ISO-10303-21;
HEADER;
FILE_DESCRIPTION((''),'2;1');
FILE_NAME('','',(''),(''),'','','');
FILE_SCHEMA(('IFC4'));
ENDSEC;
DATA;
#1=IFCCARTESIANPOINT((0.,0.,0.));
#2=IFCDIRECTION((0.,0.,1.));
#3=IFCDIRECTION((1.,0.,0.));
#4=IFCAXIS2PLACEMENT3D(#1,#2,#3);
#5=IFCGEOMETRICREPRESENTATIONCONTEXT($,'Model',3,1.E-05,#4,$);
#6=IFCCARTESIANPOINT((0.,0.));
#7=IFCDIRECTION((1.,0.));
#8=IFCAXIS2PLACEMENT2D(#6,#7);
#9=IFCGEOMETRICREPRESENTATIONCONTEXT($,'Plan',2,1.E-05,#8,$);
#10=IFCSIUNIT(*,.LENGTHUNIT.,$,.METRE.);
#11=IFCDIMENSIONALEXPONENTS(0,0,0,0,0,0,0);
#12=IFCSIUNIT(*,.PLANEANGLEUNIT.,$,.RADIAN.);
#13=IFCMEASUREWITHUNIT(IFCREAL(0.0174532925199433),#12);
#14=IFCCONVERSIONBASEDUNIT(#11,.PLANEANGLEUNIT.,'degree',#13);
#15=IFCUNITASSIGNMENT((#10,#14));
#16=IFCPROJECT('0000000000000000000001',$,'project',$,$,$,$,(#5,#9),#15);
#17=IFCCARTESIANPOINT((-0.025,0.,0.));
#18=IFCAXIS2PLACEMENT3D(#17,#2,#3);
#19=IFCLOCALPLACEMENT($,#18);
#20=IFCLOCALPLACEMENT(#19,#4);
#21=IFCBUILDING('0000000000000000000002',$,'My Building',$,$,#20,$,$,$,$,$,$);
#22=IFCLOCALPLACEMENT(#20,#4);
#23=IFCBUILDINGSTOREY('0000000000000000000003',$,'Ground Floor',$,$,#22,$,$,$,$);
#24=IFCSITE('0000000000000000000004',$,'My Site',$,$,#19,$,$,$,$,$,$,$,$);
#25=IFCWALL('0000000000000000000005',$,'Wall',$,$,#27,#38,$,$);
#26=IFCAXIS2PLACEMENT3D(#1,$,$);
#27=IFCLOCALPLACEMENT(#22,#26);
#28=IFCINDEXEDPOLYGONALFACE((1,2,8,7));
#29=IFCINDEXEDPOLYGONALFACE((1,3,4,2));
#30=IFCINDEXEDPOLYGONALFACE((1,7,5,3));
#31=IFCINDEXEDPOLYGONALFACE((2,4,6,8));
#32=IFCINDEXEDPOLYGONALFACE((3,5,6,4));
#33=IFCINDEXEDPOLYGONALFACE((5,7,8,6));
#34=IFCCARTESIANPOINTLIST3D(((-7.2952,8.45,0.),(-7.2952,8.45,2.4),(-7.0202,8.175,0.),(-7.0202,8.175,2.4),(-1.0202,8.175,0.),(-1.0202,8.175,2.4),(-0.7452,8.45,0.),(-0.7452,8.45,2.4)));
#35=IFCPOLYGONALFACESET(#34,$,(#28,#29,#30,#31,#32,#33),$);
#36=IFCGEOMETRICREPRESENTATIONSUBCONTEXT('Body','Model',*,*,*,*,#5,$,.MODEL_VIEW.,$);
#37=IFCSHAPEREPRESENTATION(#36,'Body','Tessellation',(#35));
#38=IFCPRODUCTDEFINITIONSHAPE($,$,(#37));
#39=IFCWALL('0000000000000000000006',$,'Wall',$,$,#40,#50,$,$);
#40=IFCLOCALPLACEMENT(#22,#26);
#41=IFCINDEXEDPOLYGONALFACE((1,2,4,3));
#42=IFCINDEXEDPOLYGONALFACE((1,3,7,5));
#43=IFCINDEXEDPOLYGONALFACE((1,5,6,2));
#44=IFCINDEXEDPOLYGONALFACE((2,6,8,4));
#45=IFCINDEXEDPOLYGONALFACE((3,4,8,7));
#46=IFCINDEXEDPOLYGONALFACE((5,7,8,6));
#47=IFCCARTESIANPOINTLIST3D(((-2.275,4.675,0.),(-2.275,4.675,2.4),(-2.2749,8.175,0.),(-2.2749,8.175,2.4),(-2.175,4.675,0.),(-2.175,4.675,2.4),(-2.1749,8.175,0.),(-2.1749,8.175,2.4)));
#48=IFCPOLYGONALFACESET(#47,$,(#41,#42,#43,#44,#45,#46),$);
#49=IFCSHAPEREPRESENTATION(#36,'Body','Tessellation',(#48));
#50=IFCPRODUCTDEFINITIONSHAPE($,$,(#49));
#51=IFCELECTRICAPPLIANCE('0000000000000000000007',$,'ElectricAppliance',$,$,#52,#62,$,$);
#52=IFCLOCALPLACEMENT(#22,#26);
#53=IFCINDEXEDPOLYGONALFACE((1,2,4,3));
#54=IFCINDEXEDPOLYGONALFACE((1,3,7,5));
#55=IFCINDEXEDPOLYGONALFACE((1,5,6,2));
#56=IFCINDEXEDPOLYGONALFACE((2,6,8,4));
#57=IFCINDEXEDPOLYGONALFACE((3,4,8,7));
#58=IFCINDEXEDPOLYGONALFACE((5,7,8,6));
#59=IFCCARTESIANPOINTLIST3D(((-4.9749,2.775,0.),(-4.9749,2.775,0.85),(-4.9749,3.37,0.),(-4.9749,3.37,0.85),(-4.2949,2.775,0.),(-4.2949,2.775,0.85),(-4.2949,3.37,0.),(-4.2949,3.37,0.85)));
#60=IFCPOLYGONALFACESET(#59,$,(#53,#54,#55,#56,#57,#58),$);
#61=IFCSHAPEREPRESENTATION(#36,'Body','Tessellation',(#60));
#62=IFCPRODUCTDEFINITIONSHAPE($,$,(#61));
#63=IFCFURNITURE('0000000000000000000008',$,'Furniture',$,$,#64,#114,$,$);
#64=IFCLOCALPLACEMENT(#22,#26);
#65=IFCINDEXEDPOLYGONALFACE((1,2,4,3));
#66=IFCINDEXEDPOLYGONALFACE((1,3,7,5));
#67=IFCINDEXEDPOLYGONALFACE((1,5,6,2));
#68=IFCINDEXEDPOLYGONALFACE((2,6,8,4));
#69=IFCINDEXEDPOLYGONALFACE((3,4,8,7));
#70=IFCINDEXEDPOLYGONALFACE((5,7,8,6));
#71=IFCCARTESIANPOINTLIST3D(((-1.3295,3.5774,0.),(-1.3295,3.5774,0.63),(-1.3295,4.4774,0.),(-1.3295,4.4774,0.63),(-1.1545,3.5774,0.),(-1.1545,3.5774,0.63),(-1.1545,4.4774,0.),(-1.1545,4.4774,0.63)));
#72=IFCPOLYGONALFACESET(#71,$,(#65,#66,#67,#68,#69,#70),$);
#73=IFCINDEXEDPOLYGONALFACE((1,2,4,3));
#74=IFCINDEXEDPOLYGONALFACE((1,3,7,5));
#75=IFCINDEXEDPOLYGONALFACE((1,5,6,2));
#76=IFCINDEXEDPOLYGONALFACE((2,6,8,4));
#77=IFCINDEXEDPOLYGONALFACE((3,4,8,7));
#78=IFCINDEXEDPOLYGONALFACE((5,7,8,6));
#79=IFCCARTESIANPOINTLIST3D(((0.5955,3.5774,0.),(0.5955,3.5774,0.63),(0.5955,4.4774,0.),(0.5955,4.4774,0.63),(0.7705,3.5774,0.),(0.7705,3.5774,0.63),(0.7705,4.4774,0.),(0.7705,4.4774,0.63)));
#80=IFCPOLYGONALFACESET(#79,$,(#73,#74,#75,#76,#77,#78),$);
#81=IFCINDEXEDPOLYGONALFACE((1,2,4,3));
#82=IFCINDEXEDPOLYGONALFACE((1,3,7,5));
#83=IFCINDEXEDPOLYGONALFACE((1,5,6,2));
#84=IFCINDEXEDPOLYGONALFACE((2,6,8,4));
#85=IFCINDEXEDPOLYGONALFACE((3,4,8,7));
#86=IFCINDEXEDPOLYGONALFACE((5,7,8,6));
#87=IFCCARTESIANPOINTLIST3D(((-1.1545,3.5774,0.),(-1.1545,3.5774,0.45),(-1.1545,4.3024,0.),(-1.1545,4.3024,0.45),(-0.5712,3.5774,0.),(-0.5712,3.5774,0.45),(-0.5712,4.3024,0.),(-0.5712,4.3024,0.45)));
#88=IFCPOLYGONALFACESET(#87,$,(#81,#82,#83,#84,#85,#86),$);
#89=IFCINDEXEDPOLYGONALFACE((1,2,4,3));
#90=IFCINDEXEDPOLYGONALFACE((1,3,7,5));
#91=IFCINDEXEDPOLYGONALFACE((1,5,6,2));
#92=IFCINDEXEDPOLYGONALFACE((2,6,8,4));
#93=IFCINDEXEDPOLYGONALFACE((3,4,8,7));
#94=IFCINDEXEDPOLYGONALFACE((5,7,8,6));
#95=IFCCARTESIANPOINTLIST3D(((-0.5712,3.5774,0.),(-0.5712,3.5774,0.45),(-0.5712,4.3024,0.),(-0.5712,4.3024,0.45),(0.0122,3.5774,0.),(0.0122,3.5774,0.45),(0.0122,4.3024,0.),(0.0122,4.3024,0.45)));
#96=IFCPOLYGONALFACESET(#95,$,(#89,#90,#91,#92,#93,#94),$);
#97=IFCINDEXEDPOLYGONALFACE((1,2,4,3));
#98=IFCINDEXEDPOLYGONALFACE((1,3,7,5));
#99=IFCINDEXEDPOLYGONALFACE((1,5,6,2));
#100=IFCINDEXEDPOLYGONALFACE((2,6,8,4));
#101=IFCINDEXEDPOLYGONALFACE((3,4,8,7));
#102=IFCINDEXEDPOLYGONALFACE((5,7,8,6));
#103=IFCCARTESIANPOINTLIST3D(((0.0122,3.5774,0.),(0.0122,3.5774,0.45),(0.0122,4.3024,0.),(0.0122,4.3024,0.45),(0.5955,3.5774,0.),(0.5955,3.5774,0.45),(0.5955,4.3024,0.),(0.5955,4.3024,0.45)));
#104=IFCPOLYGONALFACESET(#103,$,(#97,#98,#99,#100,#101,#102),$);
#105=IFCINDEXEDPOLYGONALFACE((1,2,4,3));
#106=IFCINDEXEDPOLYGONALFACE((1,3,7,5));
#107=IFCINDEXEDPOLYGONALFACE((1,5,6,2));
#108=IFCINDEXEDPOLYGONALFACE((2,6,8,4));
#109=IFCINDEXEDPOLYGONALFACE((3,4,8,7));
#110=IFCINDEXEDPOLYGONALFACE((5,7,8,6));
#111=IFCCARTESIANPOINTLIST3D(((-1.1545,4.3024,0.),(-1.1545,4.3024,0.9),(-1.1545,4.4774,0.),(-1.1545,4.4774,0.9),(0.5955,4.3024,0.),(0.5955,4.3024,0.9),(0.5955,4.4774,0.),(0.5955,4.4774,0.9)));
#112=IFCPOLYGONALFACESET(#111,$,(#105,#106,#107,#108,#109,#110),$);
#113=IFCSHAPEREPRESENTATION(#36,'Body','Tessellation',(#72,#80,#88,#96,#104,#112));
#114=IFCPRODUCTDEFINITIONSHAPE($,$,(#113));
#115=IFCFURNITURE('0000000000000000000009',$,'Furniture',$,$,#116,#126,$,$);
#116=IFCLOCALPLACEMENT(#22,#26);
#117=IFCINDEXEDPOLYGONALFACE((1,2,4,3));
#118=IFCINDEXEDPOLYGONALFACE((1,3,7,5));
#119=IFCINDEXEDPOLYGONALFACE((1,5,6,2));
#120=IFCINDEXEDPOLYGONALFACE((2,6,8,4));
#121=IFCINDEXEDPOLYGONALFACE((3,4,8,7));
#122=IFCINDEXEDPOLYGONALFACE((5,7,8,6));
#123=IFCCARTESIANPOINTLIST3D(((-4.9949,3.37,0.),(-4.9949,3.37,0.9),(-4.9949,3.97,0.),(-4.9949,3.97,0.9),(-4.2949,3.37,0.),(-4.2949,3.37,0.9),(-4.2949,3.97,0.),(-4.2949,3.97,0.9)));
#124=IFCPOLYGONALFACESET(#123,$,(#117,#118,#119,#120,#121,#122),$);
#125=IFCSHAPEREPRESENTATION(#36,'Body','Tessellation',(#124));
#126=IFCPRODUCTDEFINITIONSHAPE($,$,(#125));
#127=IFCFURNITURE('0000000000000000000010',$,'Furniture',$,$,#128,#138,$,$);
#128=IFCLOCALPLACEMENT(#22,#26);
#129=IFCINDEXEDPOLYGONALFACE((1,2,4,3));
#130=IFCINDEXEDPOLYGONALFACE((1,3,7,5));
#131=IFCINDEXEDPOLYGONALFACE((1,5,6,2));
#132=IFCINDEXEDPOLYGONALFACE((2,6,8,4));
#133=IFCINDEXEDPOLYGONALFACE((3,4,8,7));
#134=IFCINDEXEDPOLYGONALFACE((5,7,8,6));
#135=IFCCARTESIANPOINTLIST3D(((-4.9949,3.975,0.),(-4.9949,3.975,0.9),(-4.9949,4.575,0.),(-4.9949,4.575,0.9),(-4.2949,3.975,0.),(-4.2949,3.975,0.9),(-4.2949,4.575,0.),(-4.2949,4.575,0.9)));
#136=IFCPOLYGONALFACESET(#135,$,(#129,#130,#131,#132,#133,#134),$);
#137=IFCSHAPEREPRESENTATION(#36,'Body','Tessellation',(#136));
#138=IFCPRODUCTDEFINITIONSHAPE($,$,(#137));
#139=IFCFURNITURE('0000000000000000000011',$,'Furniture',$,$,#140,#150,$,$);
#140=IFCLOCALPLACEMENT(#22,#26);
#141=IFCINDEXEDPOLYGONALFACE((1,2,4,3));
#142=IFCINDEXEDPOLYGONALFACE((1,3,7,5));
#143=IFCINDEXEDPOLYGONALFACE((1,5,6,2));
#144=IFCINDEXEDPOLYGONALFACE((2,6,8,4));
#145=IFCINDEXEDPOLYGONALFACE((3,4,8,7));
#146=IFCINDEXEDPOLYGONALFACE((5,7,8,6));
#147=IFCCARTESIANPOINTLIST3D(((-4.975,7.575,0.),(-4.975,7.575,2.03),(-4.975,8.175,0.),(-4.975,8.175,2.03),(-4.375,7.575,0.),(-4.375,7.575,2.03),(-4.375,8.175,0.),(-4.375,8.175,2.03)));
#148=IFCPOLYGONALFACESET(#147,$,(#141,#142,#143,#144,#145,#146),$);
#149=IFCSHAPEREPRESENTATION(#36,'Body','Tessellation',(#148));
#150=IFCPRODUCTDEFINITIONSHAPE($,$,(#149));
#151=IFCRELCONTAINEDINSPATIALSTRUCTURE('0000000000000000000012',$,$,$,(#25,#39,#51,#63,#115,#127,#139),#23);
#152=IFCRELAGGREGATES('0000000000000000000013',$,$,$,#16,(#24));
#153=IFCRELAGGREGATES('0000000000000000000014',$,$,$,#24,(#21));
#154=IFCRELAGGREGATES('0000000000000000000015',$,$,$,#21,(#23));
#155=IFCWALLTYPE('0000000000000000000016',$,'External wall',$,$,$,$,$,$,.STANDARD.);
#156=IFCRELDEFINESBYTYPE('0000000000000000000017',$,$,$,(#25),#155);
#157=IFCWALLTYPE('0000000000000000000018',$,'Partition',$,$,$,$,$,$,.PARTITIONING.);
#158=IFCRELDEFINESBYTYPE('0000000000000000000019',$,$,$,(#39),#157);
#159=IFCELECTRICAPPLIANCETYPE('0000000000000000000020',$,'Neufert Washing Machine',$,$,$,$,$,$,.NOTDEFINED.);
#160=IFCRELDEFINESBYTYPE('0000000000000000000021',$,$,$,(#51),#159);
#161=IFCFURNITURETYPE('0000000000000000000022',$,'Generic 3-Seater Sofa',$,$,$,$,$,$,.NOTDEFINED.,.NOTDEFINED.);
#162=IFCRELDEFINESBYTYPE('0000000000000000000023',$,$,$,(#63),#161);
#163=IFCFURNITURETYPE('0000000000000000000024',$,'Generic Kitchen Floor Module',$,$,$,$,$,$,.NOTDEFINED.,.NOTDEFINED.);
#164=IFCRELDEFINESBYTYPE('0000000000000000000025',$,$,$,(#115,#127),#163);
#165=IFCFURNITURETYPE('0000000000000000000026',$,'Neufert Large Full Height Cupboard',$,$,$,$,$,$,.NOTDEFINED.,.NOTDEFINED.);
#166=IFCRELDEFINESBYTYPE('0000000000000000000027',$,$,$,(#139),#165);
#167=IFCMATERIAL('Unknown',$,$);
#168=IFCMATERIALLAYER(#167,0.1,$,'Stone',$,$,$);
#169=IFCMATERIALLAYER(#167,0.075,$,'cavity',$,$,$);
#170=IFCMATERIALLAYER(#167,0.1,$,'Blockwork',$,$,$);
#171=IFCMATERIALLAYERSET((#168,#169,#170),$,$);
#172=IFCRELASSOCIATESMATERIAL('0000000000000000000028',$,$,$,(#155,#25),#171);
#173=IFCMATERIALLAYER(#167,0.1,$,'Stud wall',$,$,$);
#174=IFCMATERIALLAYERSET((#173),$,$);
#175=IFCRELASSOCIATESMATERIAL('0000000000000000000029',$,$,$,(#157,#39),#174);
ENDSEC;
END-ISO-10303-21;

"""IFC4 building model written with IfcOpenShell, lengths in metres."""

from ifc_helpers import new_model, entity, si_unit, converted_unit, frame, origin_with_axes, origin_2d_with_axis, place, context, subcontext, project, spatial, line, indexed_curve, outline, extrude, clip, halfspace, shape, source, transform, mapped, material, layer, layer_set, layer_usage, type_object, type_shapes, element, save


model = new_model("IFC4")

# Units and contexts
model_context = context("Model", 3, precision=1e-05, world=origin_with_axes())
plan_context = context("Plan", 2, precision=1e-05, world=origin_2d_with_axis())
body_context_1 = subcontext(model_context, "Body", "Model", "MODEL_VIEW")
body_context_2 = subcontext(plan_context, "Body", "Plan", "PLAN_VIEW")
ifc_project = project(units=[si_unit("LENGTHUNIT", "METRE"), converted_unit("PLANEANGLEUNIT", "degree", entity("IfcReal", 0.0174532925199433), si_unit("PLANEANGLEUNIT", "RADIAN"), dimensions=[0, 0, 0, 0, 0, 0, 0])], contexts=[model_context, plan_context])

# Site, building, storey
site_placement = place(None, frame((-0.025, 0.0, 0.0), z_axis=(0.0, 0.0, 1.0), x_axis=(1.0, 0.0, 0.0)))
site = spatial("IfcSite", under=ifc_project, at=site_placement, Name="My Site")
building_placement = place(site_placement, origin_with_axes())
building = spatial("IfcBuilding", under=site, at=building_placement, Name="My Building")
storey_placement = place(building_placement, frame((0.0, 0.0, 0.0), z_axis=(0.0, 0.0, 1.0), x_axis=(1.0, 0.0, 0.0)))
storey = spatial("IfcBuildingStorey", under=building, at=storey_placement, Name="Ground Floor")

# Wall
ifc_material = material(Name="Unknown")
ifc_layer_1 = layer(ifc_material, 0.1, Name="Stone")
ifc_layer_2 = layer(ifc_material, 0.075, Name="cavity")
ifc_layer_3 = layer(ifc_material, 0.1, Name="Blockwork")
ifc_layer_set_1 = layer_set([ifc_layer_1, ifc_layer_2, ifc_layer_3])
ifc_layer_usage_1 = layer_usage(ifc_layer_set_1, "AXIS2", "POSITIVE", 0.0)
wall_type_1 = type_object("IfcWallType", Name="External wall", PredefinedType="STANDARD", material=ifc_layer_set_1)
wall_1_placement = place(storey_placement, frame((-0.7452, 8.45, 0.0), z_axis=(0.0, 0.0, 1.0), x_axis=(-1.0, 0.0, 0.0)))
element("IfcWall", 1, at=wall_1_placement, inside=storey, type_object=wall_type_1, material=ifc_layer_usage_1, Name="Wall", shapes=[
    shape(body_context_1, "Body", "Clipping", [clip(clip(extrude(outline(indexed_curve([(0.0, 0.0), (0.0, 0.275), (6.55, 0.275), (6.55, 0.0), (0.0, 0.0)], self_intersect=False)), origin_with_axes(), (0.0, 0.0, 1.0), 2.4), halfspace(frame((6.55, 0.0, 0.0), z_axis=(0.707106, 0.707107, 0.0), x_axis=(0.707107, -0.707106, 0.0)), False)), halfspace(frame((0.0, 0.0, 0.0), z_axis=(-0.707106, 0.707107, 0.0), x_axis=(0.707108, 0.707106, 0.0)), False))]),
    shape(body_context_1, "Body", "Clipping", [clip(clip(extrude(outline(indexed_curve([(0.0, 0.0), (0.0, 0.275), (6.55, 0.275), (6.55, 0.0), (0.0, 0.0)], self_intersect=False)), origin_with_axes(), (0.0, 0.0, 1.0), 2.4), halfspace(frame((6.55, 0.0, 0.0), z_axis=(0.707106, 0.707107, 0.0), x_axis=(0.707107, -0.707106, 0.0)), False)), halfspace(frame((0.0, 0.0, 0.0), z_axis=(-0.707106, 0.707107, 0.0), x_axis=(0.707108, 0.707106, 0.0)), False))]),
    shape(body_context_1, "Body", "Clipping", [clip(extrude(outline(indexed_curve([(0.0, 0.0), (0.0, 0.275), (4.5048, 0.275), (4.5048, 0.0), (0.0, 0.0)], self_intersect=False)), origin_with_axes(), (0.0, 0.0, 1.0), 2.4), halfspace(frame((4.5048, 0.0, 0.0), z_axis=(0.707106, 0.707107, 0.0), x_axis=(0.707107, -0.707106, 0.0)), False))]),
])

# Shared definitions
ifc_layer_4 = layer(ifc_material, 0.1, Name="Stud wall")
ifc_layer_set_2 = layer_set([ifc_layer_4])
wall_type_2 = type_object("IfcWallType", Name="Partition", PredefinedType="PARTITIONING", material=ifc_layer_set_2)

# Wall
ifc_layer_usage_2 = layer_usage(ifc_layer_set_2, "AXIS2", "POSITIVE", 0.0)
wall_2_placement = place(storey_placement, frame((-2.175, 4.675, 0.0), z_axis=(0.0, 0.0, 1.0), x_axis=(0.0, 1.0, 0.0)))
element("IfcWall", 2, at=wall_2_placement, inside=storey, type_object=wall_type_2, material=ifc_layer_usage_2, Name="Wall", context=body_context_1, shape_type="SweptSolid", body=[
    extrude(outline(indexed_curve([(0.0, 0.0), (0.0, 0.1), (3.5, 0.1), (3.5, 0.0), (0.0, 0.0)], self_intersect=False)), origin_with_axes(), (0.0, 0.0, 1.0), 2.4),
])

# Electric appliance
electric_appliance_type_1 = type_object("IfcElectricApplianceType", Name="Neufert Washing Machine", PredefinedType="NOTDEFINED")
shared_shape_1 = source(origin_with_axes(), body_context_1, "Body", "SweptSolid", [
    extrude(outline(indexed_curve([(0.0, 0.0), (0.595, 0.0), (0.595, 0.68), (0.0, 0.68)], segments=[line(1, 2, 3, 4, 1)])), origin_with_axes(), (0.0, 0.0, 1.0), 0.85),
])
shared_shape_2 = source(origin_with_axes(), body_context_2, "Body", "Curve2D", [
    entity("IfcIndexedPolyCurve", entity("IfcCartesianPointList2D", [[0.0, 0.0], [0.595, 0.0], [0.595, 0.68], [0.0, 0.68]]), [entity("IfcLineIndex", [1, 2, 3, 4, 1])]),
    entity("IfcCircle", entity("IfcAxis2Placement2D", entity("IfcCartesianPoint", [0.2975, 0.34])), 0.1785),
    entity("IfcCircle", entity("IfcAxis2Placement2D", entity("IfcCartesianPoint", [0.2975, 0.34])), 0.0595),
])
type_shapes(electric_appliance_type_1, [shared_shape_1, shared_shape_2])
electric_appliance_1_placement = place(storey_placement, frame((-4.2949, 2.775, 0.0), z_axis=(0.0, 0.0, 1.0), x_axis=(0.0, 1.0, 0.0)))
element("IfcElectricAppliance", 3, at=electric_appliance_1_placement, inside=storey, type_object=electric_appliance_type_1, Name="ElectricAppliance", shapes=[
    shape(body_context_1, "Body", "MappedRepresentation", [mapped(shared_shape_1, transform((0.0, 0.0, 0.0), x_axis=(1.0, 0.0, 0.0), y_axis=(0.0, 1.0, 0.0), z_axis=(0.0, 0.0, 1.0), scale=1.0))]),
    shape(body_context_2, "Body", "MappedRepresentation", [mapped(shared_shape_2, transform((0.0, 0.0, 0.0), x_axis=(1.0, 0.0, 0.0), y_axis=(0.0, 1.0, 0.0), z_axis=(0.0, 0.0, 1.0), scale=1.0))]),
])

# Furniture
furniture_type_1 = type_object("IfcFurnitureType", Name="Generic 3-Seater Sofa", AssemblyPlace="NOTDEFINED", PredefinedType="NOTDEFINED")
shared_shape_3 = source(origin_with_axes(), body_context_1, "Body", "SweptSolid", [
    extrude(outline(indexed_curve([(0.0, 0.0), (0.175, 0.0), (0.175, 0.9), (0.0, 0.9)], segments=[line(1, 2, 3, 4, 1)])), frame((-1.05, -0.9, 0.0), z_axis=(0.0, 0.0, 1.0), x_axis=(1.0, 0.0, 0.0)), (0.0, 0.0, 1.0), 0.63),
    extrude(outline(indexed_curve([(0.0, 0.0), (0.175, 0.0), (0.175, 0.9), (0.0, 0.9)], segments=[line(1, 2, 3, 4, 1)])), frame((0.875, -0.9, 0.0), z_axis=(0.0, 0.0, 1.0), x_axis=(1.0, 0.0, 0.0)), (0.0, 0.0, 1.0), 0.63),
    extrude(outline(indexed_curve([(0.175, 0.0), (0.7583, 0.0), (0.7583, 0.725), (0.175, 0.725)], segments=[line(1, 2, 3, 4, 1)])), frame((-1.05, -0.9, 0.0), z_axis=(0.0, 0.0, 1.0), x_axis=(1.0, 0.0, 0.0)), (0.0, 0.0, 1.0), 0.45),
    extrude(outline(indexed_curve([(0.7583, 0.0), (1.3417, 0.0), (1.3417, 0.725), (0.7583, 0.725)], segments=[line(1, 2, 3, 4, 1)])), frame((-1.05, -0.9, 0.0), z_axis=(0.0, 0.0, 1.0), x_axis=(1.0, 0.0, 0.0)), (0.0, 0.0, 1.0), 0.45),
    extrude(outline(indexed_curve([(1.3417, 0.0), (1.925, 0.0), (1.925, 0.725), (1.3417, 0.725)], segments=[line(1, 2, 3, 4, 1)])), frame((-1.05, -0.9, 0.0), z_axis=(0.0, 0.0, 1.0), x_axis=(1.0, 0.0, 0.0)), (0.0, 0.0, 1.0), 0.45),
    extrude(outline(indexed_curve([(0.175, 0.725), (1.925, 0.725), (1.925, 0.9), (0.175, 0.9)], segments=[line(1, 2, 3, 4, 1)])), frame((-1.05, -0.9, 0.0), z_axis=(0.0, 0.0, 1.0), x_axis=(1.0, 0.0, 0.0)), (0.0, 0.0, 1.0), 0.9),
])
shared_shape_4 = source(origin_with_axes(), body_context_2, "Body", "Curve2D", [
    entity("IfcIndexedPolyCurve", entity("IfcCartesianPointList2D", [[-1.05, -0.9], [-0.875, -0.9], [-0.875, 0.0], [-1.05, 0.0]]), [entity("IfcLineIndex", [1, 2, 3, 4, 1])]),
    entity("IfcIndexedPolyCurve", entity("IfcCartesianPointList2D", [[0.875, -0.9], [1.05, -0.9], [1.05, 0.0], [0.875, 0.0]]), [entity("IfcLineIndex", [1, 2, 3, 4, 1])]),
    entity("IfcIndexedPolyCurve", entity("IfcCartesianPointList2D", [[-0.875, -0.9], [-0.2917, -0.9], [-0.2917, -0.175], [-0.875, -0.175]]), [entity("IfcLineIndex", [1, 2, 3, 4, 1])]),
    entity("IfcIndexedPolyCurve", entity("IfcCartesianPointList2D", [[-0.2917, -0.9], [0.2917, -0.9], [0.2917, -0.175], [-0.2917, -0.175]]), [entity("IfcLineIndex", [1, 2, 3, 4, 1])]),
    entity("IfcIndexedPolyCurve", entity("IfcCartesianPointList2D", [[0.2917, -0.9], [0.875, -0.9], [0.875, -0.175], [0.2917, -0.175]]), [entity("IfcLineIndex", [1, 2, 3, 4, 1])]),
    entity("IfcIndexedPolyCurve", entity("IfcCartesianPointList2D", [[-0.875, -0.175], [0.875, -0.175], [0.875, 0.0], [-0.875, 0.0]]), [entity("IfcLineIndex", [1, 2, 3, 4, 1])]),
])
type_shapes(furniture_type_1, [shared_shape_3, shared_shape_4])
furniture_1_placement = place(storey_placement, frame((-0.2795, 4.4774, 0.0), z_axis=(0.0, 0.0, 1.0), x_axis=(1.0, 0.0, 0.0)))
element("IfcFurniture", 4, at=furniture_1_placement, inside=storey, type_object=furniture_type_1, Name="Furniture", shapes=[
    shape(body_context_1, "Body", "MappedRepresentation", [mapped(shared_shape_3, transform((0.0, 0.0, 0.0), x_axis=(1.0, 0.0, 0.0), y_axis=(0.0, 1.0, 0.0), z_axis=(0.0, 0.0, 1.0), scale=1.0))]),
    shape(body_context_2, "Body", "MappedRepresentation", [mapped(shared_shape_4, transform((0.0, 0.0, 0.0), x_axis=(1.0, 0.0, 0.0), y_axis=(0.0, 1.0, 0.0), z_axis=(0.0, 0.0, 1.0), scale=1.0))]),
])
furniture_type_2 = type_object("IfcFurnitureType", Name="Generic Kitchen Floor Module", AssemblyPlace="NOTDEFINED", PredefinedType="NOTDEFINED")
shared_shape_5 = source(origin_with_axes(), body_context_1, "Body", "SweptSolid", [
    extrude(outline(indexed_curve([(0.0, 0.0), (0.6, 0.0), (0.6, 0.7), (0.0, 0.7)], segments=[line(1, 2, 3, 4, 1)])), origin_with_axes(), (0.0, 0.0, 1.0), 0.9),
])
shared_shape_6 = source(origin_with_axes(), body_context_2, "Body", "Curve2D", [
    entity("IfcIndexedPolyCurve", entity("IfcCartesianPointList2D", [[0.0, 0.0], [0.6, 0.0], [0.6, 0.7], [0.0, 0.7]]), [entity("IfcLineIndex", [1, 2, 3, 4, 1])]),
])
type_shapes(furniture_type_2, [shared_shape_5, shared_shape_6])
for number, where, z_axis, x_axis, name in (
    (5, (-4.2949, 3.37, 0.0), (0.0, 0.0, 1.0), (0.0, 1.0, 0.0), "Furniture"),
    (6, (-4.2949, 3.975, 0.0), (0.0, 0.0, 1.0), (0.0, 1.0, 0.0), "Furniture"),
):
    element("IfcFurniture", number, at=place(storey_placement, frame(where, z_axis=z_axis, x_axis=x_axis)), inside=storey, type_object=furniture_type_2, Name=name, shapes=[
        shape(body_context_1, "Body", "MappedRepresentation", [mapped(shared_shape_5, transform((0.0, 0.0, 0.0), x_axis=(1.0, 0.0, 0.0), y_axis=(0.0, 1.0, 0.0), z_axis=(0.0, 0.0, 1.0), scale=1.0))]),
        shape(body_context_2, "Body", "MappedRepresentation", [mapped(shared_shape_6, transform((0.0, 0.0, 0.0), x_axis=(1.0, 0.0, 0.0), y_axis=(0.0, 1.0, 0.0), z_axis=(0.0, 0.0, 1.0), scale=1.0))]),
    ])
furniture_type_3 = type_object("IfcFurnitureType", Name="Neufert Large Full Height Cupboard", AssemblyPlace="NOTDEFINED", PredefinedType="NOTDEFINED")
shared_shape_7 = source(origin_with_axes(), body_context_1, "Body", "SweptSolid", [
    extrude(outline(indexed_curve([(0.0, 0.0), (0.6, 0.0), (0.6, 0.6), (0.0, 0.6)], segments=[line(1, 2, 3, 4, 1)])), origin_with_axes(), (0.0, 0.0, 1.0), 2.03),
])
shared_shape_8 = source(origin_with_axes(), body_context_2, "Body", "Curve2D", [
    entity("IfcIndexedPolyCurve", entity("IfcCartesianPointList2D", [[0.0, 0.0], [0.6, 0.0], [0.6, 0.6], [0.0, 0.6]]), [entity("IfcLineIndex", [1, 2, 3, 4, 1])]),
])
type_shapes(furniture_type_3, [shared_shape_7, shared_shape_8])
furniture_2_placement = place(storey_placement, frame((-4.975, 7.575, 0.0), z_axis=(0.0, 0.0, 1.0), x_axis=(1.0, 0.0, 0.0)))
element("IfcFurniture", 7, at=furniture_2_placement, inside=storey, type_object=furniture_type_3, Name="Furniture", shapes=[
    shape(body_context_1, "Body", "MappedRepresentation", [mapped(shared_shape_7, transform((0.0, 0.0, 0.0), x_axis=(1.0, 0.0, 0.0), y_axis=(0.0, 1.0, 0.0), z_axis=(0.0, 0.0, 1.0), scale=1.0))]),
    shape(body_context_2, "Body", "MappedRepresentation", [mapped(shared_shape_8, transform((0.0, 0.0, 0.0), x_axis=(1.0, 0.0, 0.0), y_axis=(0.0, 1.0, 0.0), z_axis=(0.0, 0.0, 1.0), scale=1.0))]),
])

save(model, "model.ifc")
